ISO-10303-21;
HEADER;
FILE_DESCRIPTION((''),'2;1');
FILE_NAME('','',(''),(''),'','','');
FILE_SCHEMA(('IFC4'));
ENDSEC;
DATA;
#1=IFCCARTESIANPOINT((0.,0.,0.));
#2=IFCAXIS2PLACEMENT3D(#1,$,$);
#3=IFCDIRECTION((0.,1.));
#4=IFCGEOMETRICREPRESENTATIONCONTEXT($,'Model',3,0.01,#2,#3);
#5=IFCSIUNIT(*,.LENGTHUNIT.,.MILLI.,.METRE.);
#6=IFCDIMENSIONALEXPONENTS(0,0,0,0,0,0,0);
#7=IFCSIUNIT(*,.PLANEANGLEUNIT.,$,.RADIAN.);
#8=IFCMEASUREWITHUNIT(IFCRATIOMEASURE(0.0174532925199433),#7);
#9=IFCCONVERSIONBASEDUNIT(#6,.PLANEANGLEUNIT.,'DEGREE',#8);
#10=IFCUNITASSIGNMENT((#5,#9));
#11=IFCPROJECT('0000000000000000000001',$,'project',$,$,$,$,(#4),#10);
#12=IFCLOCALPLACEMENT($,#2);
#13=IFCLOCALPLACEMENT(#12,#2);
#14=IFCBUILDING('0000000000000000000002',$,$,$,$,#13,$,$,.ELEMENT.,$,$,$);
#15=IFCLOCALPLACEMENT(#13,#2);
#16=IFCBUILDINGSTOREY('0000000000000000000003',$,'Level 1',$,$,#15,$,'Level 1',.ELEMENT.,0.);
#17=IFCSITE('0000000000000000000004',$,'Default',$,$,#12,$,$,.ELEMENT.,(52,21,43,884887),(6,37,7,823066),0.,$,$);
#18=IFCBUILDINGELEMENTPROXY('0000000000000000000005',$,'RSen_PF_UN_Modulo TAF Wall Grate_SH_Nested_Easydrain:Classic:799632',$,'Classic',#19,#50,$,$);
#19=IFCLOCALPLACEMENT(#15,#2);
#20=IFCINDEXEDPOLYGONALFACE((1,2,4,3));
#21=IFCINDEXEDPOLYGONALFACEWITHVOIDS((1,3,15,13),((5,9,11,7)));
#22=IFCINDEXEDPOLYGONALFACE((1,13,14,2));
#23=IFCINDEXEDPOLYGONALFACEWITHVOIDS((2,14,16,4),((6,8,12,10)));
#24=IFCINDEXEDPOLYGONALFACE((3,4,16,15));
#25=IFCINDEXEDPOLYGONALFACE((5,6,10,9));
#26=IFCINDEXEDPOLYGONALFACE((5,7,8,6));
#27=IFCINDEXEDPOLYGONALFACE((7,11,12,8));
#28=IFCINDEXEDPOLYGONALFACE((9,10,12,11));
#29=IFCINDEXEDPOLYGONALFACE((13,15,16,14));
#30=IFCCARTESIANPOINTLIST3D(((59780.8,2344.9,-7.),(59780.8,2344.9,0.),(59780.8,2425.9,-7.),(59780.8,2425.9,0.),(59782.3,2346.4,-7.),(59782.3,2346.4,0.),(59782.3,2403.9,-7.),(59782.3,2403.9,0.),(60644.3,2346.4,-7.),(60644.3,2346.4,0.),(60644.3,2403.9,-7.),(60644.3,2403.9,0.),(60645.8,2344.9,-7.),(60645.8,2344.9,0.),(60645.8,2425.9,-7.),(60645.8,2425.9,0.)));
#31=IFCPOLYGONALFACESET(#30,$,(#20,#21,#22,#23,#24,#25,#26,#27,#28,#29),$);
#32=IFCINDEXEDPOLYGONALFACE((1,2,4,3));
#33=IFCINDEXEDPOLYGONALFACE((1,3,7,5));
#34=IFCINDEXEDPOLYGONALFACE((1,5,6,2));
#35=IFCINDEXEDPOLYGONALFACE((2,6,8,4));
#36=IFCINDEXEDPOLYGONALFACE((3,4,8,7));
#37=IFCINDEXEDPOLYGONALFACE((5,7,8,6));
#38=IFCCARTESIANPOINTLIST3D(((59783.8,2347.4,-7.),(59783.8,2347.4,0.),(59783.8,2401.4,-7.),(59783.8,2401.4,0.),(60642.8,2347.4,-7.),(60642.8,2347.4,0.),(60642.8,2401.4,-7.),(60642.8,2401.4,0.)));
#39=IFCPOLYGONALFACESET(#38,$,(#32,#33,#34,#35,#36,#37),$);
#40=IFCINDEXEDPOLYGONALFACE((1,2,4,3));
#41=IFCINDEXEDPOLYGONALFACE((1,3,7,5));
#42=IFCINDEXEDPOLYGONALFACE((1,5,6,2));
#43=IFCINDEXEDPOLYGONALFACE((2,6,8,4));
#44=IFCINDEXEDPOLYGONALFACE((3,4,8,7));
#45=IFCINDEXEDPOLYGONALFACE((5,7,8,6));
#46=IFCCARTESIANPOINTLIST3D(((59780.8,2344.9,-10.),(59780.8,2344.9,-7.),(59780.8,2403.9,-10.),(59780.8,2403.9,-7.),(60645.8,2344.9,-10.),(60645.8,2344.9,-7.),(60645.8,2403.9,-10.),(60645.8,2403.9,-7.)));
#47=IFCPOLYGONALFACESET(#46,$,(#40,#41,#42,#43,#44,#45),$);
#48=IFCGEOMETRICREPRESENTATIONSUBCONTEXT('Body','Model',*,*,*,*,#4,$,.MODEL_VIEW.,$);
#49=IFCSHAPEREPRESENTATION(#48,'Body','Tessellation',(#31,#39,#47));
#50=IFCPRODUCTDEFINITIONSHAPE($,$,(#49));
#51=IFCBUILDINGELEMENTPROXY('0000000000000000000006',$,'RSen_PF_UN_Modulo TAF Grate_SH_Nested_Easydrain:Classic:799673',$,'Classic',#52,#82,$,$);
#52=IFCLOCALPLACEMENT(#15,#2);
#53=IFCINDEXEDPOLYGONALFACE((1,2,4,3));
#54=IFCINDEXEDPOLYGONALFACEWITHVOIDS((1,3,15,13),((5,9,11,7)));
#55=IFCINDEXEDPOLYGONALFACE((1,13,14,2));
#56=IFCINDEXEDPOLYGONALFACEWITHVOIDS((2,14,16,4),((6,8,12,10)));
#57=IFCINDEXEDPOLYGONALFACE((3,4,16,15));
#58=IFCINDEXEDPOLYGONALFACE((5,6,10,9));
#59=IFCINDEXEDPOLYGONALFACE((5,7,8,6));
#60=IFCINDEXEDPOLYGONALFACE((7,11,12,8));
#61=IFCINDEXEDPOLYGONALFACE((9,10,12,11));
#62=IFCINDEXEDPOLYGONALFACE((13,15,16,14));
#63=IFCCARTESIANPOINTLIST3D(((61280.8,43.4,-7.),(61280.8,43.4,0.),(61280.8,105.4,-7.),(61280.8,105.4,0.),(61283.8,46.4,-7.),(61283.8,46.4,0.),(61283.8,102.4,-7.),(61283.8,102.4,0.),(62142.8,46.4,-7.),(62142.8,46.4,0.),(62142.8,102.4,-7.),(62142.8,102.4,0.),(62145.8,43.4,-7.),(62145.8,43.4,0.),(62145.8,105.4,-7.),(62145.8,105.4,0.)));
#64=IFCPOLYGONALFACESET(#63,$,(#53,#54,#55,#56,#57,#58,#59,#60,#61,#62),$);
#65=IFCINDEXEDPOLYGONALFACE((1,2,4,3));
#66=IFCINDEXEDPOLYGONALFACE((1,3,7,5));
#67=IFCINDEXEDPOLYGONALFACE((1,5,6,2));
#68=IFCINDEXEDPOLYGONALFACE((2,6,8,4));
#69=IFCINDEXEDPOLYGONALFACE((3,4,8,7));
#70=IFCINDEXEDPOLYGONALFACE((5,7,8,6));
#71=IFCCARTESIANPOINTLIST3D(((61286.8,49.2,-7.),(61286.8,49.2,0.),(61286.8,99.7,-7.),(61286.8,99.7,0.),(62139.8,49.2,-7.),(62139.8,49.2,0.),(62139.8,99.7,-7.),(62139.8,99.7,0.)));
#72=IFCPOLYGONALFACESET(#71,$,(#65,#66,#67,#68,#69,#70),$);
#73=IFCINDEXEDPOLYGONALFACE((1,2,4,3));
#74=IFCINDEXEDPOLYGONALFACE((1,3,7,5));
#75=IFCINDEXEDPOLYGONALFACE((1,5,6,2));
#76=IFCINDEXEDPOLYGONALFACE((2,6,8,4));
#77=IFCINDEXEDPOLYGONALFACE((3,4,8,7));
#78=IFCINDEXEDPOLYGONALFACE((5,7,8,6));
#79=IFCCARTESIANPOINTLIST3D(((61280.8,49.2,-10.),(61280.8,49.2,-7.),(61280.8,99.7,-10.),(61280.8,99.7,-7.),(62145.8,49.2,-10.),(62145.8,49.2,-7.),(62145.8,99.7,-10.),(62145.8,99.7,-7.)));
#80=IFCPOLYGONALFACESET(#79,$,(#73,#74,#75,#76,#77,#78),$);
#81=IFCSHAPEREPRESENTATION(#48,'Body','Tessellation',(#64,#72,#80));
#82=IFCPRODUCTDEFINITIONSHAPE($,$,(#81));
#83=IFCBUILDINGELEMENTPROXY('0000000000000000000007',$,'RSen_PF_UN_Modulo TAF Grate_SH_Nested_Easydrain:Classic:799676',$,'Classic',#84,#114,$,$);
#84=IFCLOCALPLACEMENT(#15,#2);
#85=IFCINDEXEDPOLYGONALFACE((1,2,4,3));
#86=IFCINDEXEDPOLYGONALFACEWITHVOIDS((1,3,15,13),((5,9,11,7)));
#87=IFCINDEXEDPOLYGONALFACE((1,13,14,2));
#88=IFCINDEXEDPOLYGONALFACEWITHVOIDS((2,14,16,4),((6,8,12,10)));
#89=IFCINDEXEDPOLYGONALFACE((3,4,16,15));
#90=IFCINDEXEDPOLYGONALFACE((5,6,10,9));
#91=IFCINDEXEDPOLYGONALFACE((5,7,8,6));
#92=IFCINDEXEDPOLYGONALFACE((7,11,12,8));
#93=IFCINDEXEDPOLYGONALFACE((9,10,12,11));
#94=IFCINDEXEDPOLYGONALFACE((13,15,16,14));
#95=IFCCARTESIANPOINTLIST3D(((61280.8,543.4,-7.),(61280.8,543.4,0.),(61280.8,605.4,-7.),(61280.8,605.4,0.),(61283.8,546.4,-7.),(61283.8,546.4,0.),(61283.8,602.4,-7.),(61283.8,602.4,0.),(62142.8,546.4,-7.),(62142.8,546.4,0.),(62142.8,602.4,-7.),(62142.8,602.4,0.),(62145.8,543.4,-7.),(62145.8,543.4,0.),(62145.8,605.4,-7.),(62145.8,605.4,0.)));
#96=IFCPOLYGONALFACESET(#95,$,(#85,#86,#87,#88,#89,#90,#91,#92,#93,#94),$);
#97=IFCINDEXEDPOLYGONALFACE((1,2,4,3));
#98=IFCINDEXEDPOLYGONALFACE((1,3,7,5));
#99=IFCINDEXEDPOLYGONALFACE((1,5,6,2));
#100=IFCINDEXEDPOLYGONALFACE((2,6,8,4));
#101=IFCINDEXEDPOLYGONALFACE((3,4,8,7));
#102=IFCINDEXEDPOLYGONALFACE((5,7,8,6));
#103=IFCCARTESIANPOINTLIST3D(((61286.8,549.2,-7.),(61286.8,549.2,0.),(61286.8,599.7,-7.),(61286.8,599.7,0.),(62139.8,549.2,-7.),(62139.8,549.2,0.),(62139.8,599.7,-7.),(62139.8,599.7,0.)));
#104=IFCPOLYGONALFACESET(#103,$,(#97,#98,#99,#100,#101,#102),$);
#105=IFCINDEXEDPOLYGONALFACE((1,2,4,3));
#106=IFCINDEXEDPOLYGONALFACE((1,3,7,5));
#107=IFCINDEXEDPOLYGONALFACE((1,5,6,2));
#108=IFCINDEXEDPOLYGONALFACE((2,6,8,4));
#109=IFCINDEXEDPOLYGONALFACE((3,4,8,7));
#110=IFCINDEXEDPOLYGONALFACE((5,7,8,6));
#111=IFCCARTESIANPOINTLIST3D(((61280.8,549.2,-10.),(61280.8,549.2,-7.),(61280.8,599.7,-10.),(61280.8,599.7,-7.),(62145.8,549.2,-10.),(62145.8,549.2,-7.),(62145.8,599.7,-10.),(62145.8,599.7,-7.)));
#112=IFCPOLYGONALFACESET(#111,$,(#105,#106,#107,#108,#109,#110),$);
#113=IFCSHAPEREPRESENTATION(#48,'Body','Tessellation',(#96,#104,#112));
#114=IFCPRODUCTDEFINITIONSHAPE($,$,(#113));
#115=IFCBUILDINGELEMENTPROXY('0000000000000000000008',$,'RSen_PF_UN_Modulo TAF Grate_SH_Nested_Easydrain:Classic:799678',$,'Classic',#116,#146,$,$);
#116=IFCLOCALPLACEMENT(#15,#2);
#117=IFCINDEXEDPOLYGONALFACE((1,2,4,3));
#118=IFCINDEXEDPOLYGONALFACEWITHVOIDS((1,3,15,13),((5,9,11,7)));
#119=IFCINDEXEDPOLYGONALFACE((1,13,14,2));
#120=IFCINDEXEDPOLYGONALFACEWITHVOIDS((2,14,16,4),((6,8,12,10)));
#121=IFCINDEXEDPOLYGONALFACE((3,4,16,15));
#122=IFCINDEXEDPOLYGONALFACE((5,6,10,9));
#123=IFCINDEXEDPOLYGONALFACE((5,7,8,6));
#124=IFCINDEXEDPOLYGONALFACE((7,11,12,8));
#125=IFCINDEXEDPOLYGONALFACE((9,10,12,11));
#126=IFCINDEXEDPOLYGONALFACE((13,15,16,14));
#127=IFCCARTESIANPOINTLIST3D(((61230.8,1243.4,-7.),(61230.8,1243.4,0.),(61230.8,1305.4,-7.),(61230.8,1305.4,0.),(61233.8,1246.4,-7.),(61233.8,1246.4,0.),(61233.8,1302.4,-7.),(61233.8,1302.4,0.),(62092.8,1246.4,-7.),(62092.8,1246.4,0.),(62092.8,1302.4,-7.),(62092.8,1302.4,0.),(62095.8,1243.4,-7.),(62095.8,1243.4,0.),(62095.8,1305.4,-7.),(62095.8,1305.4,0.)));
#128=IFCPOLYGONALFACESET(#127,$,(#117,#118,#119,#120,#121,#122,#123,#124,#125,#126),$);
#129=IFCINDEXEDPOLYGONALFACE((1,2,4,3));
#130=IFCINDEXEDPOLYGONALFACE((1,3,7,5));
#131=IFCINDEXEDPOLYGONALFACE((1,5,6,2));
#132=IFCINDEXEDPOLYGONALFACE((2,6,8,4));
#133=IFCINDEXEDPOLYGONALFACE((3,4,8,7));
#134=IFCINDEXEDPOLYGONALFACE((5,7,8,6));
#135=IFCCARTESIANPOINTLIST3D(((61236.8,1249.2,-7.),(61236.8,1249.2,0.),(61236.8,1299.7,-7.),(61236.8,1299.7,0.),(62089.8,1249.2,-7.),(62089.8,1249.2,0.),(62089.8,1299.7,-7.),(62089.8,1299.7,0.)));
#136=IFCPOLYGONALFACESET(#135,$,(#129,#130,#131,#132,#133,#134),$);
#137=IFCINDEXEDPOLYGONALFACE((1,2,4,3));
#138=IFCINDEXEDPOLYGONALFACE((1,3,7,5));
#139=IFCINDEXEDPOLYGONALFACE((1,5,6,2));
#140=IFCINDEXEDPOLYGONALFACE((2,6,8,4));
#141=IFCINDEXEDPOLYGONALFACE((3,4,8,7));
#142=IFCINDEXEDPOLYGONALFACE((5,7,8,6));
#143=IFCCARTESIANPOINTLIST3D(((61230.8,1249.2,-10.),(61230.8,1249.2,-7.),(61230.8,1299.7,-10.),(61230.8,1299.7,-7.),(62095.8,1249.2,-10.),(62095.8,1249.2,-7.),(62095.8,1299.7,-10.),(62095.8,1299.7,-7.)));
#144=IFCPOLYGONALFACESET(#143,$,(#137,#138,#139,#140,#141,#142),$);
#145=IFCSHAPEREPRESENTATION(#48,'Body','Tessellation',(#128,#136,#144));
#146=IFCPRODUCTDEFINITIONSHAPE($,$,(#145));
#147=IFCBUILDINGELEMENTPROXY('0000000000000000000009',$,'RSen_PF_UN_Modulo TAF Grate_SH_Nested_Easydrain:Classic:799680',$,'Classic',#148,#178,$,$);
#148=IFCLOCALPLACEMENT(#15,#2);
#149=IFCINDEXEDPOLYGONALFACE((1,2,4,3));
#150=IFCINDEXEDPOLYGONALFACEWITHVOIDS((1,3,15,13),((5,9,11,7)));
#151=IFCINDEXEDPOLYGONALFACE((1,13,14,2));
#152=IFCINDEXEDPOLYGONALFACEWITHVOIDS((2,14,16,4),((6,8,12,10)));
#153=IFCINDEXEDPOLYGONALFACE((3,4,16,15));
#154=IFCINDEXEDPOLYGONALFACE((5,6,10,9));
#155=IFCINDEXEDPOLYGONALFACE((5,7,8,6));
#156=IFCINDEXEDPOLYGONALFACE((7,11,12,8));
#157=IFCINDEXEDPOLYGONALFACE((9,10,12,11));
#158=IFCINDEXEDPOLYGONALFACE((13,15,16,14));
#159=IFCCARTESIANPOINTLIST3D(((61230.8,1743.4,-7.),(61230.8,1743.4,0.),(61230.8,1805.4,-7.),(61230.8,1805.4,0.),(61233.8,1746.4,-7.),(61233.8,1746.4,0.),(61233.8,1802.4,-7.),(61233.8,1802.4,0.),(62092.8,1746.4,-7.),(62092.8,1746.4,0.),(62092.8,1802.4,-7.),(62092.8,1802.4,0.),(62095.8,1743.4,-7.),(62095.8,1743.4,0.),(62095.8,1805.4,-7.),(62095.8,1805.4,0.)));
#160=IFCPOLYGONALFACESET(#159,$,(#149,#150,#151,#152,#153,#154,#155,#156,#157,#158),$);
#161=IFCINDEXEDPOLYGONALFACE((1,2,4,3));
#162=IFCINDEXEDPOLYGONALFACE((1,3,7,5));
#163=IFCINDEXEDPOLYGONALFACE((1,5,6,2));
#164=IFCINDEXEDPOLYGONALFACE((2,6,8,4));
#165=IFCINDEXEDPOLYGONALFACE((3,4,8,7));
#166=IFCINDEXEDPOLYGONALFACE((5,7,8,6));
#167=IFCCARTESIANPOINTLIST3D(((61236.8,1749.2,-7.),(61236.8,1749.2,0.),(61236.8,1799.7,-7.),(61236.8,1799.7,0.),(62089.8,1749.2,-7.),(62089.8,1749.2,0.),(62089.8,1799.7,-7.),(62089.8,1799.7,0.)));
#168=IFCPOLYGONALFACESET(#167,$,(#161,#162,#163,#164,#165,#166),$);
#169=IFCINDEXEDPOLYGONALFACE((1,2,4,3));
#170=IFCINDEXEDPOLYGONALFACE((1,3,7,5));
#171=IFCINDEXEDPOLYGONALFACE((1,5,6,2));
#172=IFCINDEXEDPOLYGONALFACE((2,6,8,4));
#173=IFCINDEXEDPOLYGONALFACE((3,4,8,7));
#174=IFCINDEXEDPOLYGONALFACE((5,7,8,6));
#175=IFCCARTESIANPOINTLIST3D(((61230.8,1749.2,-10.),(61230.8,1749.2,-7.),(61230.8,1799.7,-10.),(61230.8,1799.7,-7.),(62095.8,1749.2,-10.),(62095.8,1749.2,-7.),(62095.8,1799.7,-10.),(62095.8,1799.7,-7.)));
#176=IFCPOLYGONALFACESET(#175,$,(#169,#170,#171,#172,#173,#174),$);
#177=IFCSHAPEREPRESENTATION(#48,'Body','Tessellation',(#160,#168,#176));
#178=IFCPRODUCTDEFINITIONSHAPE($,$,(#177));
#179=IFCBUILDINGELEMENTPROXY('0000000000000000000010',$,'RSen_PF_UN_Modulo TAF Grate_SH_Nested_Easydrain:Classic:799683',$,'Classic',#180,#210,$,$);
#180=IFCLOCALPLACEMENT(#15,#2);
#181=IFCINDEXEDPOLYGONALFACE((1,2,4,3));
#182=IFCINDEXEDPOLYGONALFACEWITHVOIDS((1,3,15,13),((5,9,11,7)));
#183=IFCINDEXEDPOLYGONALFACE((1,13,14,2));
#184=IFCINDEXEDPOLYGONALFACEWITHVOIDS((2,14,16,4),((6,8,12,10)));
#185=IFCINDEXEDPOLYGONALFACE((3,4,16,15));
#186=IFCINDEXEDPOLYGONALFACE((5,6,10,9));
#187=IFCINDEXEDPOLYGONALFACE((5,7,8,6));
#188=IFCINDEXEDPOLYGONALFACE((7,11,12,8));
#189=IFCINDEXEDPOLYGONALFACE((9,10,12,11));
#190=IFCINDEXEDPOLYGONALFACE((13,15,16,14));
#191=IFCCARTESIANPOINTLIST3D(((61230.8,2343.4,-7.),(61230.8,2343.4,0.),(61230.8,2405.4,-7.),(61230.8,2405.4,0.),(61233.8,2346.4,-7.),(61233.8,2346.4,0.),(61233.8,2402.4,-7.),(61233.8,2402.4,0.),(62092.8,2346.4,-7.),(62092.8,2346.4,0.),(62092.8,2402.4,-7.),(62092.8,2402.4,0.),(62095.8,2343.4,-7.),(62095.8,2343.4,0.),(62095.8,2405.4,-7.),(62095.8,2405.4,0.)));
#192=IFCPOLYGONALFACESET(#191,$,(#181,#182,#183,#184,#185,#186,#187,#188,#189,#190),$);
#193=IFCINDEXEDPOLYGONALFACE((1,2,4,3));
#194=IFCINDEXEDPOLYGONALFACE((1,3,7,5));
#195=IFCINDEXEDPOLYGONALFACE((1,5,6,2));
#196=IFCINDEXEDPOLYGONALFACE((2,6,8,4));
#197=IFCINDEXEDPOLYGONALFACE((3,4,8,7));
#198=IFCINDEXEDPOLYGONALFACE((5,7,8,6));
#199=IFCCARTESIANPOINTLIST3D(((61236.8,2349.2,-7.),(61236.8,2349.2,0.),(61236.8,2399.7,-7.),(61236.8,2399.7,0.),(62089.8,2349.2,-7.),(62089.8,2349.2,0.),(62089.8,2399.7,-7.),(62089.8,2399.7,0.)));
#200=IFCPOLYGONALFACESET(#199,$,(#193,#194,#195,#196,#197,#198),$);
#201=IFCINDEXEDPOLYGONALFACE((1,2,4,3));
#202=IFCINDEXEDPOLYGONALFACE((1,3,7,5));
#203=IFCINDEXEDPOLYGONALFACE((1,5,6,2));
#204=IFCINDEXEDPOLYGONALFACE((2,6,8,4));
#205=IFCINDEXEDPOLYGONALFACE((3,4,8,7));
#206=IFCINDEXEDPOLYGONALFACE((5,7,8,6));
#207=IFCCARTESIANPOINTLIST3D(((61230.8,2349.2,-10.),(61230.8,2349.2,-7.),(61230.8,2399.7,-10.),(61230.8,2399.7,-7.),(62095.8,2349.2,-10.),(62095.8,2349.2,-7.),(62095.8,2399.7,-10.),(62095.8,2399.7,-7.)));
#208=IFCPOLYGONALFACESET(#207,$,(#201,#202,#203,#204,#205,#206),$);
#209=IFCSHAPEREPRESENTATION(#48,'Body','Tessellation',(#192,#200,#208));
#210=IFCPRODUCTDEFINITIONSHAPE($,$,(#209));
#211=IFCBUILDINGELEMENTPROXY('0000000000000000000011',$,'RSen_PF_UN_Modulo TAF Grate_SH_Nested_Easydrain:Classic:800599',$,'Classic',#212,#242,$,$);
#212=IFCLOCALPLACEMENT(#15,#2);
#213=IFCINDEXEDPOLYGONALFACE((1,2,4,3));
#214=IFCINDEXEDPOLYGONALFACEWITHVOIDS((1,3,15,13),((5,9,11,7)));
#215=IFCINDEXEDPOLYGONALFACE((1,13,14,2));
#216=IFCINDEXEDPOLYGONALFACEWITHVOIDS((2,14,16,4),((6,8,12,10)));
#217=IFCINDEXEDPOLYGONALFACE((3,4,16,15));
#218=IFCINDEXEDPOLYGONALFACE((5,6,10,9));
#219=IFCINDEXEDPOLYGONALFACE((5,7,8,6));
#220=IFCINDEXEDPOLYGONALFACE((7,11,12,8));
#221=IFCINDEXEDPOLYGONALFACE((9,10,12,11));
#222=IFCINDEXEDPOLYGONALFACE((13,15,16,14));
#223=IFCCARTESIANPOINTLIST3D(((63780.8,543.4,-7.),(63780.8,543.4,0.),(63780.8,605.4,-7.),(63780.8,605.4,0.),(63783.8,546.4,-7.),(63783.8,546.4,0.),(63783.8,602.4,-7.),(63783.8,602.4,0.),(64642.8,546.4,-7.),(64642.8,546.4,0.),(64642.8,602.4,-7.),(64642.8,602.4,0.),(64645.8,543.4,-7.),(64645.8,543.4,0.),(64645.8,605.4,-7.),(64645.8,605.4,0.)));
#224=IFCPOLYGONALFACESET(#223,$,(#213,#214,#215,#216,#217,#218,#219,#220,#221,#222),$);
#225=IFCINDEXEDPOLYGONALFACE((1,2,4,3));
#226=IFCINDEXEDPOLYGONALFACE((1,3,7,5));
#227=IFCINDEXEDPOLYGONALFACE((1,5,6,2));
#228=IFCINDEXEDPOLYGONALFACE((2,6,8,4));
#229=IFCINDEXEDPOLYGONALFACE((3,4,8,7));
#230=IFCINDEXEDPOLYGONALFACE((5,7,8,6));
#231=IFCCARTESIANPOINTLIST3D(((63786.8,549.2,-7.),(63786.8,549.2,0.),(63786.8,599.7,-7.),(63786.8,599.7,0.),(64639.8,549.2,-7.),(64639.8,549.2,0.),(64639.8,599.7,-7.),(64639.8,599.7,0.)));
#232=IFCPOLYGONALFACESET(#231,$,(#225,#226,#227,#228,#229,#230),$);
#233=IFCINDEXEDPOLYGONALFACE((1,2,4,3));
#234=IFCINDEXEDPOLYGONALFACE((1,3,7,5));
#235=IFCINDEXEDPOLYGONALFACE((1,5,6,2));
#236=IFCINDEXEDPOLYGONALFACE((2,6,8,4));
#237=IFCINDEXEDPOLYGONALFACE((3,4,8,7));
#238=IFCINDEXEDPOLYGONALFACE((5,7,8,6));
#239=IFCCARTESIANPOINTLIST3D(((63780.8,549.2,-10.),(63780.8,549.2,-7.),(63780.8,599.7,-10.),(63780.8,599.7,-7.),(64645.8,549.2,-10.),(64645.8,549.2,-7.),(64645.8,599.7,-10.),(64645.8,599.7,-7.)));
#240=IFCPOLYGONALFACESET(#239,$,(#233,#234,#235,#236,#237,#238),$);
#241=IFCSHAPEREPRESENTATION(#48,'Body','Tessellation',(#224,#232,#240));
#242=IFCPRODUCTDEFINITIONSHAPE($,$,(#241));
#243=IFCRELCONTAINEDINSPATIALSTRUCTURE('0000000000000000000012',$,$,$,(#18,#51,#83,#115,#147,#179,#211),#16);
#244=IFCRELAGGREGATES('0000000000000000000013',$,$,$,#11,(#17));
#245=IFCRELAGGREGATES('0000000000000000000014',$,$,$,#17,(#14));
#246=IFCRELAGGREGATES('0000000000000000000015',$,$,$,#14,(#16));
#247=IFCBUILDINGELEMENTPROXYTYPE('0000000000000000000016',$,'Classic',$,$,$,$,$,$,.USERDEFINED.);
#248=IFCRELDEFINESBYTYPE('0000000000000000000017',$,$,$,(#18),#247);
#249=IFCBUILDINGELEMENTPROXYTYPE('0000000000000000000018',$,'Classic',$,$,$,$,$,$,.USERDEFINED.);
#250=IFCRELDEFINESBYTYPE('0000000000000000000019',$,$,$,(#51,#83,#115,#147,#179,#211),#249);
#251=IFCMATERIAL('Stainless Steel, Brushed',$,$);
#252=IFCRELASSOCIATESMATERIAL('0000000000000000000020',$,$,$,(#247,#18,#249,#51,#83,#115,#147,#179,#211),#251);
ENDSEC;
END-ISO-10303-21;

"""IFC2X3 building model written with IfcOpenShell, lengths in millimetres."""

from ifc_helpers import new_model, entity, si_unit, converted_unit, direction, frame, frame_2d, origin, origin_2d_with_axis, place, context, subcontext, project, spatial, polyline, rectangle, outline, extrude, source, transform, mapped, material, type_object, type_shapes, element, save


model = new_model("IFC2X3")

# Units and contexts
model_context = context("Model", 3, precision=0.01, world=origin(), true_north=direction((0.0, 1.0)))
body_context = subcontext(model_context, "Body", "Model", "MODEL_VIEW")
ifc_project = project(units=[si_unit("LENGTHUNIT", "METRE", prefix="MILLI"), converted_unit("PLANEANGLEUNIT", "DEGREE", entity("IfcRatioMeasure", 0.0174532925199433), si_unit("PLANEANGLEUNIT", "RADIAN"), dimensions=[0, 0, 0, 0, 0, 0, 0])], contexts=[model_context])

# Site, building, storey
site_placement = place(None, origin())
site = spatial("IfcSite", under=ifc_project, at=site_placement, Name="Default", CompositionType="ELEMENT", RefLatitude=(52, 21, 43, 884887), RefLongitude=(6, 37, 7, 823066), RefElevation=0.0)
building_placement = place(site_placement, origin())
building = spatial("IfcBuilding", under=site, at=building_placement, CompositionType="ELEMENT")
storey_placement = place(building_placement, origin())
storey = spatial("IfcBuildingStorey", under=building, at=storey_placement, Name="Level 1", LongName="Level 1", CompositionType="ELEMENT", Elevation=0.0)

# Shared definitions
ifc_material_1 = material(Name="Stainless Steel, Brushed")

# Building element proxies
building_element_proxy_type_1 = type_object("IfcBuildingElementProxyType", Name="Classic", PredefinedType="USERDEFINED", material=ifc_material_1)
shared_shape_1 = source(origin(), body_context, "Body", "SweptSolid", [
    extrude(outline(polyline([(-432.5, -40.5), (432.5, -40.5), (432.5, 40.5), (-432.5, 40.5), (-432.5, -40.5)]), holes=[polyline([(-431.0, -18.5), (-431.0, 39.0), (431.0, 39.0), (431.0, -18.5), (-431.0, -18.5)])]), frame((0.0, 11.0, 0.0), z_axis=(0.0, 0.0, 1.0), x_axis=(-1.0, 0.0, 0.0)), (0.0, 0.0, 1.0), 7.0),
    extrude(rectangle(XDim=859.0, YDim=54.0, at=origin_2d_with_axis()), frame((0.0, 0.0, 0.0), z_axis=(0.0, 0.0, 1.0), x_axis=(-1.0, 0.0, 0.0)), (0.0, 0.0, 1.0), 7.0),
    extrude(rectangle(XDim=865.0, YDim=59.0, at=origin_2d_with_axis()), frame((0.0, 0.0, -3.0), z_axis=(0.0, 0.0, 1.0), x_axis=(-1.0, 0.0, 0.0)), (0.0, 0.0, 1.0), 3.0),
])
type_shapes(building_element_proxy_type_1, [shared_shape_1])
proxy_placement = place(storey_placement, frame((60213.3, 2374.4, -7.0)))
element("IfcBuildingElementProxy", 1, at=proxy_placement, inside=storey, type_object=building_element_proxy_type_1, material=ifc_material_1, Name="RSen_PF_UN_Modulo TAF Wall Grate_SH_Nested_Easydrain:Classic:799632", ObjectType="Classic", context=body_context, shape_type="MappedRepresentation", body=[
    mapped(shared_shape_1, transform((0.0, 0.0, 0.0), scale=1.0)),
])
building_element_proxy_type_2 = type_object("IfcBuildingElementProxyType", Name="Classic", PredefinedType="USERDEFINED", material=ifc_material_1)
shared_shape_2 = source(origin(), body_context, "Body", "SweptSolid", [
    extrude(outline(polyline([(-432.5, -31.0), (432.5, -31.0), (432.5, 31.0), (-432.5, 31.0), (-432.5, -31.0)]), holes=[polyline([(-429.5, -28.0), (-429.5, 28.0), (429.5, 28.0), (429.5, -28.0), (-429.5, -28.0)])]), frame((0.0, 0.0, 0.0), z_axis=(0.0, 0.0, 1.0), x_axis=(-1.0, 0.0, 0.0)), (0.0, 0.0, 1.0), 7.0),
    extrude(rectangle(XDim=853.0, YDim=50.5, at=frame_2d((0.0, 0.0), x_axis=(1.0, 0.0))), frame((0.0, 0.0, 0.0), z_axis=(0.0, 0.0, 1.0), x_axis=(-1.0, 0.0, 0.0)), (0.0, 0.0, 1.0), 7.0),
    extrude(rectangle(XDim=865.0, YDim=50.5, at=origin_2d_with_axis()), frame((0.0, 0.0, -3.0), z_axis=(0.0, 0.0, 1.0), x_axis=(-1.0, 0.0, 0.0)), (0.0, 0.0, 1.0), 3.0),
])
type_shapes(building_element_proxy_type_2, [shared_shape_2])
for number, where, name in (
    (2, (61713.3, 74.4, -7.0), "RSen_PF_UN_Modulo TAF Grate_SH_Nested_Easydrain:Classic:799673"),
    (3, (61713.3, 574.4, -7.0), "RSen_PF_UN_Modulo TAF Grate_SH_Nested_Easydrain:Classic:799676"),
    (4, (61663.3, 1274.4, -7.0), "RSen_PF_UN_Modulo TAF Grate_SH_Nested_Easydrain:Classic:799678"),
    (5, (61663.3, 1774.4, -7.0), "RSen_PF_UN_Modulo TAF Grate_SH_Nested_Easydrain:Classic:799680"),
    (6, (61663.3, 2374.4, -7.0), "RSen_PF_UN_Modulo TAF Grate_SH_Nested_Easydrain:Classic:799683"),
    (7, (64213.3, 574.4, -7.0), "RSen_PF_UN_Modulo TAF Grate_SH_Nested_Easydrain:Classic:800599"),
):
    element("IfcBuildingElementProxy", number, at=place(storey_placement, frame(where)), inside=storey, type_object=building_element_proxy_type_2, material=ifc_material_1, Name=name, ObjectType="Classic", context=body_context, shape_type="MappedRepresentation", body=[
        mapped(shared_shape_2, transform((0.0, 0.0, 0.0), scale=1.0)),
    ])

save(model, "model.ifc")
